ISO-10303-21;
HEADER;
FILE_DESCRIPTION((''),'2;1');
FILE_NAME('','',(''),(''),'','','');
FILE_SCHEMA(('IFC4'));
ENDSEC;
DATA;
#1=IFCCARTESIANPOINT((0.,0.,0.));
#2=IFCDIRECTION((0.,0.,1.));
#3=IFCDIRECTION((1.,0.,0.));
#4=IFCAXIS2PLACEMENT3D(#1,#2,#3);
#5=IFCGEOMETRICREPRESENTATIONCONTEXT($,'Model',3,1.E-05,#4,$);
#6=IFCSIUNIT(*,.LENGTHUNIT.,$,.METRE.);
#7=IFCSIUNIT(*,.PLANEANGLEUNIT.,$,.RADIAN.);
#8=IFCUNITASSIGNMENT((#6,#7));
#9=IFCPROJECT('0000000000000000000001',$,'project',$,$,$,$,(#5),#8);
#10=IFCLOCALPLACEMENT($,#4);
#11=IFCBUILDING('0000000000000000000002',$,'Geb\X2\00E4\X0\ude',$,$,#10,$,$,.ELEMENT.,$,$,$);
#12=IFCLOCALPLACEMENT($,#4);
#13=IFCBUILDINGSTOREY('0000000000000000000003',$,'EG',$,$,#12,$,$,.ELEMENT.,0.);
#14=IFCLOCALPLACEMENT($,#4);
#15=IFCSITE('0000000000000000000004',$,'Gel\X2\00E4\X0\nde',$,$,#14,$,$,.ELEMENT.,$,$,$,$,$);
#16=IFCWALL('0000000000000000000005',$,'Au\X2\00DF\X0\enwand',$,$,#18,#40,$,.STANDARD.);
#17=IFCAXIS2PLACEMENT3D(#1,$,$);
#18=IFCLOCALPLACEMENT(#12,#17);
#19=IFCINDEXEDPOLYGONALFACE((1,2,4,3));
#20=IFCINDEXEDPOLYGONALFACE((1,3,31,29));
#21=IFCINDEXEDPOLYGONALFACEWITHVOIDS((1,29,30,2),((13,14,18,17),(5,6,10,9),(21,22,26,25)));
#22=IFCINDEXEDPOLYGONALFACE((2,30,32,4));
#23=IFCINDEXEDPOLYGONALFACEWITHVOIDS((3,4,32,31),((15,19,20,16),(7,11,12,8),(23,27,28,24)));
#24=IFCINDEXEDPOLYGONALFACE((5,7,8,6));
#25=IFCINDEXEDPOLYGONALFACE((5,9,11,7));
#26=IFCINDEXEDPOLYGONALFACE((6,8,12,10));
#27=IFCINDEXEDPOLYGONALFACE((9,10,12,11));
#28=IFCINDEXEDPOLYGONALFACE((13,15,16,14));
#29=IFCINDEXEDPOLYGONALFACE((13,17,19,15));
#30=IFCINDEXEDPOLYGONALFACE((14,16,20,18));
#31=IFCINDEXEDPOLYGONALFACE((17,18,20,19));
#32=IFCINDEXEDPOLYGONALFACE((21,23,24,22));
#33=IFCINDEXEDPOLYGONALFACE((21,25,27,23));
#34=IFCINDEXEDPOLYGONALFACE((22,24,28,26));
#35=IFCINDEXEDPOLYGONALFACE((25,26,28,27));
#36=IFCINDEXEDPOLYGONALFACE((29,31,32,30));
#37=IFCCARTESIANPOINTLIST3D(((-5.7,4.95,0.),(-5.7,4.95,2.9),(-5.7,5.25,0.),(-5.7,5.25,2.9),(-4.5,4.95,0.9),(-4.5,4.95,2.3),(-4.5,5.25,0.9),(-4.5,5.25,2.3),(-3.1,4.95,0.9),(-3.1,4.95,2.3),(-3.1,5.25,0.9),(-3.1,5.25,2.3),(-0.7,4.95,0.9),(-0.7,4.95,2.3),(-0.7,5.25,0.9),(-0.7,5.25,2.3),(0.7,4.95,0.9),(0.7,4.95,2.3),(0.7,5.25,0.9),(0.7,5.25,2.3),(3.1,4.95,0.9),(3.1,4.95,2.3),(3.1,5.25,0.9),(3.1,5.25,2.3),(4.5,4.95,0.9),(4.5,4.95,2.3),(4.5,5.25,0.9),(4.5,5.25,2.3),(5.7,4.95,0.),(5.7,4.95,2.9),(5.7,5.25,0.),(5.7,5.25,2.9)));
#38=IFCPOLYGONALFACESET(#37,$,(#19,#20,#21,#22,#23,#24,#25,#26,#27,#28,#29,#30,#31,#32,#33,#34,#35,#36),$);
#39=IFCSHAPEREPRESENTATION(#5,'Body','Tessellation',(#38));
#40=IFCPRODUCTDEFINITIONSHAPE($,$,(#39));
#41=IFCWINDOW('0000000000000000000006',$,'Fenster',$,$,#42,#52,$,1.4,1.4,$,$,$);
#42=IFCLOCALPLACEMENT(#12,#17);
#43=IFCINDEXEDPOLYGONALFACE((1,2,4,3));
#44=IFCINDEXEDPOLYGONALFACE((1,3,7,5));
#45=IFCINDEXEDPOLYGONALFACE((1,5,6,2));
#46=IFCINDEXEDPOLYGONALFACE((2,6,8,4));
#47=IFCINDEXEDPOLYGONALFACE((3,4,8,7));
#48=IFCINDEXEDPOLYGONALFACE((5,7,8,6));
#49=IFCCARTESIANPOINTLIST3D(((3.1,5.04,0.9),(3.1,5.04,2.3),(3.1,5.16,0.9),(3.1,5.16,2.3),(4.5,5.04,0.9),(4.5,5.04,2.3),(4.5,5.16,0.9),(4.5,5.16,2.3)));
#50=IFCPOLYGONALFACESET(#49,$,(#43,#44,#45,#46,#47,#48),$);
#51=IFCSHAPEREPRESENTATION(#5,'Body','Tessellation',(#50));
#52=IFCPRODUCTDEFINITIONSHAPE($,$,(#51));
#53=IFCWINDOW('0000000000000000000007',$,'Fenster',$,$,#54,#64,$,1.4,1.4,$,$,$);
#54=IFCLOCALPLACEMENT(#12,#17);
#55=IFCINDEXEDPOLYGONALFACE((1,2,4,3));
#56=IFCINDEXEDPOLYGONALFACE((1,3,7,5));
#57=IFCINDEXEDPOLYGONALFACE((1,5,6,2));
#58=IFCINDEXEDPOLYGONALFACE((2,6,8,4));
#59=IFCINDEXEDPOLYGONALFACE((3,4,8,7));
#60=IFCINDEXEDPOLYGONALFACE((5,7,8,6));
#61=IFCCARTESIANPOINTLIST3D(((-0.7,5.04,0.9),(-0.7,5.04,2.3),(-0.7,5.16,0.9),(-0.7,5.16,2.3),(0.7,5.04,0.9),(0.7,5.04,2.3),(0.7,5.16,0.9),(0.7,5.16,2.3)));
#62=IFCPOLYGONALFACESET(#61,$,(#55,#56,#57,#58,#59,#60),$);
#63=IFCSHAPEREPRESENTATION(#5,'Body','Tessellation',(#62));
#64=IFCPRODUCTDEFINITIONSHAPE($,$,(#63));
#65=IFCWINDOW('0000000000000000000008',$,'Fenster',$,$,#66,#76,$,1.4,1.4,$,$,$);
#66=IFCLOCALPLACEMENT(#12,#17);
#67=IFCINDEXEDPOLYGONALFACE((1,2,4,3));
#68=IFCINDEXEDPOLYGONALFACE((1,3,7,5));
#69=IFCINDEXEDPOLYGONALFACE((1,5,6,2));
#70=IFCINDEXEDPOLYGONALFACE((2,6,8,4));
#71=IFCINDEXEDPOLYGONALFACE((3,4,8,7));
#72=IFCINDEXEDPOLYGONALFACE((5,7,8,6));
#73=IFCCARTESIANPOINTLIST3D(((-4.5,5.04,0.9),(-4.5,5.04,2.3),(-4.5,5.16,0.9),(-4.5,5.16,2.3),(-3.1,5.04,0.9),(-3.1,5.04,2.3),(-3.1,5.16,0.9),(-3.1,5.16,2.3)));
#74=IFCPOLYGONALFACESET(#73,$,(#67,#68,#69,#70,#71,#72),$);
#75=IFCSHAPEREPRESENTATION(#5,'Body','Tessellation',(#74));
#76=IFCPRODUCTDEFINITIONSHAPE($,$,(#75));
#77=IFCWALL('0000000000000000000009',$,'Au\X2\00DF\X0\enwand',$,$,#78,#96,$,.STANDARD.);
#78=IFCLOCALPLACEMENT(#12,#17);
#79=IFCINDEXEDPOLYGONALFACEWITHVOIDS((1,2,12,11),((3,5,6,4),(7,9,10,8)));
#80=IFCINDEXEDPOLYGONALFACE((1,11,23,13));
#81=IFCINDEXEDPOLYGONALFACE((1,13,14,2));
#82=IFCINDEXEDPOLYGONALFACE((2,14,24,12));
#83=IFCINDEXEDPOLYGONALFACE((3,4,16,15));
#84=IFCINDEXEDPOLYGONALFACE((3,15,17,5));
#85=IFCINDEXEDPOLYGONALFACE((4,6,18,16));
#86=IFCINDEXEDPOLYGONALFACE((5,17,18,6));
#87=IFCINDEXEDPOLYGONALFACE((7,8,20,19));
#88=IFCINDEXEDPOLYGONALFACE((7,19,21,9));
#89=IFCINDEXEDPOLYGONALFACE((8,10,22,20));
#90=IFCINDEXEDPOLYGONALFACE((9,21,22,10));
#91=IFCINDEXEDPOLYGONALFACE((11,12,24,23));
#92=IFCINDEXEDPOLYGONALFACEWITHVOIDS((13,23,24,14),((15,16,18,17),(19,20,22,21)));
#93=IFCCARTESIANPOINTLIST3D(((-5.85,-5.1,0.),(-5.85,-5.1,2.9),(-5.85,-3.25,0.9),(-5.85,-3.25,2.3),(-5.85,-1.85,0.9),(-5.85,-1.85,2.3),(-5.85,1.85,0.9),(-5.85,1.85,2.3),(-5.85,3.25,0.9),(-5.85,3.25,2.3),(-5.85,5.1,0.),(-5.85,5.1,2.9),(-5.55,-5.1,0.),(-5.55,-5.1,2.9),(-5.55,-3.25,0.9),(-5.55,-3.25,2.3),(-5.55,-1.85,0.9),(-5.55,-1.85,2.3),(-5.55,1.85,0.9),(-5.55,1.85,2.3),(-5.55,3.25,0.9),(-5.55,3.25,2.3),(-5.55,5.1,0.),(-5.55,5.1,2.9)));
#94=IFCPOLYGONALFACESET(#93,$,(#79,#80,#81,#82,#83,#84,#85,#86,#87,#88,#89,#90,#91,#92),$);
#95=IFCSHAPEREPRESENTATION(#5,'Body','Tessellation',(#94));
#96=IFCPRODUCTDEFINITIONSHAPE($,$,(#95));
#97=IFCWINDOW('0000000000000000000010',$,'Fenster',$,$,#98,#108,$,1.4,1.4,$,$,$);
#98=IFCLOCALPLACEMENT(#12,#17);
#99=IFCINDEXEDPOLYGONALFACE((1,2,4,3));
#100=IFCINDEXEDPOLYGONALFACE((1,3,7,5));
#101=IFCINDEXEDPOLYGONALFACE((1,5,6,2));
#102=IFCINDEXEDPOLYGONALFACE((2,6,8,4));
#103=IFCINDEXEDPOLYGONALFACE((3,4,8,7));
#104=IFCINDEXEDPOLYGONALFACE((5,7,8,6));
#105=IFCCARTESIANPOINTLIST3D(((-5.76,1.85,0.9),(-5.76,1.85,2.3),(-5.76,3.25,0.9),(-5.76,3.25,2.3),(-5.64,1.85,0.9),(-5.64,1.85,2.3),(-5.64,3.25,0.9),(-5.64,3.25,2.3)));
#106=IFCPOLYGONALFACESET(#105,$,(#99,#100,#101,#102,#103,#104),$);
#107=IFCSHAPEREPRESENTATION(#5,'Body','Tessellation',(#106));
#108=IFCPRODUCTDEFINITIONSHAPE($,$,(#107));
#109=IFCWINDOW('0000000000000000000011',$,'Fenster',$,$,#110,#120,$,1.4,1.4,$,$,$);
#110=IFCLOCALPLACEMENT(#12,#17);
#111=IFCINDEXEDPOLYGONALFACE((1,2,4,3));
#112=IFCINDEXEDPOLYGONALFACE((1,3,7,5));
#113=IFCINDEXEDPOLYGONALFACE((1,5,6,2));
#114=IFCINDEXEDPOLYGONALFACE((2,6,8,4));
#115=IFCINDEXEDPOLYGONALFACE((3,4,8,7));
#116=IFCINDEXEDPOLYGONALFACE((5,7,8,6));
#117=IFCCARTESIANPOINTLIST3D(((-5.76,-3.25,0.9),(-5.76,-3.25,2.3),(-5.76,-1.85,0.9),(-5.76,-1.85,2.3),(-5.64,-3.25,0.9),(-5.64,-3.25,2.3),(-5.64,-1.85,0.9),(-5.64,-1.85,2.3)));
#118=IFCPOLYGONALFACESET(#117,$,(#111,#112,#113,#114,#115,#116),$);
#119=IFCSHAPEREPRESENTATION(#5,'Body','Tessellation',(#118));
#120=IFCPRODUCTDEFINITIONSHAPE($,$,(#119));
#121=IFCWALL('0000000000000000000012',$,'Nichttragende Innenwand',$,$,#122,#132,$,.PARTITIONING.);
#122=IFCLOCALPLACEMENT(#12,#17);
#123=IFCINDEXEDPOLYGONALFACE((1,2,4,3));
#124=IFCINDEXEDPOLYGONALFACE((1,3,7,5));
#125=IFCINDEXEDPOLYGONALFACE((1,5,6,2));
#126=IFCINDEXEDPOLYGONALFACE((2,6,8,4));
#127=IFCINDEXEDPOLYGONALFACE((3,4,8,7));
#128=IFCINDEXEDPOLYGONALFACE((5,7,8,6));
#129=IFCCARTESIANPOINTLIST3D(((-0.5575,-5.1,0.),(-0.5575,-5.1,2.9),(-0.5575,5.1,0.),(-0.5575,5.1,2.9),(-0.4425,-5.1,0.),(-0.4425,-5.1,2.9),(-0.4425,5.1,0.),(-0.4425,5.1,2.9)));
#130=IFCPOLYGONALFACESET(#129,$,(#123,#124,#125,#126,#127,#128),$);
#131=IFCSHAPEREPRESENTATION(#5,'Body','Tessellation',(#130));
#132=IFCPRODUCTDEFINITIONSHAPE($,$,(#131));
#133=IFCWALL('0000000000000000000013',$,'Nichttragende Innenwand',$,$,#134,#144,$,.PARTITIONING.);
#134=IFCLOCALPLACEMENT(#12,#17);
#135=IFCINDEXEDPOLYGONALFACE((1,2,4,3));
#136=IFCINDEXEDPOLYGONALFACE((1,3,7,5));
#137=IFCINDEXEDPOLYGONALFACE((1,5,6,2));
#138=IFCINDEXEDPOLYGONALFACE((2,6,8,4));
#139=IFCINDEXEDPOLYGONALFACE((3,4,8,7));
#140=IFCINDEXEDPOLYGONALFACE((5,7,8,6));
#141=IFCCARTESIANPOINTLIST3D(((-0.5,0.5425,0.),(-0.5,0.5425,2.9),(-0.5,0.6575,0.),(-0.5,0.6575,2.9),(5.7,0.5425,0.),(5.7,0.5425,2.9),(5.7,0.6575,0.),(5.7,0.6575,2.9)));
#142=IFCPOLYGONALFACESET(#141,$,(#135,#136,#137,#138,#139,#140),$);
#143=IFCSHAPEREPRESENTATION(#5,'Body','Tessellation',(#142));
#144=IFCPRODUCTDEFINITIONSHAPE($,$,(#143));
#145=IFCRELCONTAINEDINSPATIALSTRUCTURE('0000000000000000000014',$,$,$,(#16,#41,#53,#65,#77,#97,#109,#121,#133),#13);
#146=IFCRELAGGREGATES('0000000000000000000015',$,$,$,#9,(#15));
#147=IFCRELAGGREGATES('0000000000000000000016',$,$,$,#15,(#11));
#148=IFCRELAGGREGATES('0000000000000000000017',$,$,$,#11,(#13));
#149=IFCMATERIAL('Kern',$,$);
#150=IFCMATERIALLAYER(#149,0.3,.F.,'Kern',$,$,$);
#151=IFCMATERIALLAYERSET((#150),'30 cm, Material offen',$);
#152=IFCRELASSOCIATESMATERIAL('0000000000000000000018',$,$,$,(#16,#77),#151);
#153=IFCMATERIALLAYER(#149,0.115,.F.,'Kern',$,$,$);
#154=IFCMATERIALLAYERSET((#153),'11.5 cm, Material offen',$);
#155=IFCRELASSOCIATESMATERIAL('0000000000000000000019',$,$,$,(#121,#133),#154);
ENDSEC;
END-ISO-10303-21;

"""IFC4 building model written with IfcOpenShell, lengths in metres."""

from ifc_helpers import new_model, si_unit, frame, origin_with_axes, origin_2d, place, context, project, spatial, rectangle, extrude, material, layer, layer_set, element, fill, save


model = new_model("IFC4")

# Units and contexts
model_context = context("Model", 3, precision=1e-05, world=origin_with_axes())
ifc_project = project(units=[si_unit("LENGTHUNIT", "METRE"), si_unit("PLANEANGLEUNIT", "RADIAN")], contexts=[model_context])

# Site, building, storey
site_placement = place(None, origin_with_axes())
site = spatial("IfcSite", under=ifc_project, at=site_placement, Name="Gelände", CompositionType="ELEMENT")
building_placement = place(None, origin_with_axes())
building = spatial("IfcBuilding", under=site, at=building_placement, Name="Gebäude", CompositionType="ELEMENT")
storey_placement = place(None, origin_with_axes())
storey = spatial("IfcBuildingStorey", under=building, at=storey_placement, Name="EG", CompositionType="ELEMENT", Elevation=0.0)

# Shared definitions
ifc_material = material(Name="Kern")
ifc_layer_1 = layer(ifc_material, 0.3, ventilated=False, Name="Kern")
ifc_layer_set_1 = layer_set([ifc_layer_1], Name="30 cm, Material offen")

# Walls, openings, windows
wall_1_placement = place(None, frame((0.0, 5.1, 0.0), z_axis=(0.0, 0.0, 1.0), x_axis=(-1.0, 0.0, 0.0)))
wall_1 = element("IfcWall", 1, at=wall_1_placement, inside=storey, material=ifc_layer_set_1, Name="Außenwand", PredefinedType="STANDARD", context=model_context, shape_type="SweptSolid", body=[
    extrude(rectangle(XDim=11.4, YDim=0.3, at=origin_2d()), origin_with_axes(), (0.0, 0.0, 1.0), 2.9),
])
opening_1_placement = place(wall_1_placement, frame((-3.8, 0.0, 0.9), z_axis=(0.0, 0.0, 1.0), x_axis=(1.0, 0.0, 0.0)))
opening_1 = element("IfcOpeningElement", 2, at=opening_1_placement, cuts=wall_1, PredefinedType="OPENING", context=model_context, shape_type="SweptSolid", body=[
    extrude(rectangle(XDim=1.4, YDim=0.34, at=origin_2d()), origin_with_axes(), (0.0, 0.0, 1.0), 1.4),
])
opening_2_placement = place(wall_1_placement, frame((0.0, 0.0, 0.9), z_axis=(0.0, 0.0, 1.0), x_axis=(1.0, 0.0, 0.0)))
opening_2 = element("IfcOpeningElement", 3, at=opening_2_placement, cuts=wall_1, PredefinedType="OPENING", context=model_context, shape_type="SweptSolid", body=[
    extrude(rectangle(XDim=1.4, YDim=0.34, at=origin_2d()), origin_with_axes(), (0.0, 0.0, 1.0), 1.4),
])
opening_3_placement = place(wall_1_placement, frame((3.8, 0.0, 0.9), z_axis=(0.0, 0.0, 1.0), x_axis=(1.0, 0.0, 0.0)))
opening_3 = element("IfcOpeningElement", 4, at=opening_3_placement, cuts=wall_1, PredefinedType="OPENING", context=model_context, shape_type="SweptSolid", body=[
    extrude(rectangle(XDim=1.4, YDim=0.34, at=origin_2d()), origin_with_axes(), (0.0, 0.0, 1.0), 1.4),
])
window_1_placement = place(opening_1_placement, origin_with_axes())
window_1 = element("IfcWindow", 5, at=window_1_placement, inside=storey, Name="Fenster", OverallHeight=1.4, OverallWidth=1.4, context=model_context, shape_type="SweptSolid", body=[
    extrude(rectangle(XDim=1.4, YDim=0.12, at=origin_2d()), origin_with_axes(), (0.0, 0.0, 1.0), 1.4),
])
fill(opening_1, window_1)
window_2_placement = place(opening_2_placement, origin_with_axes())
window_2 = element("IfcWindow", 6, at=window_2_placement, inside=storey, Name="Fenster", OverallHeight=1.4, OverallWidth=1.4, context=model_context, shape_type="SweptSolid", body=[
    extrude(rectangle(XDim=1.4, YDim=0.12, at=origin_2d()), origin_with_axes(), (0.0, 0.0, 1.0), 1.4),
])
fill(opening_2, window_2)
window_3_placement = place(opening_3_placement, origin_with_axes())
window_3 = element("IfcWindow", 7, at=window_3_placement, inside=storey, Name="Fenster", OverallHeight=1.4, OverallWidth=1.4, context=model_context, shape_type="SweptSolid", body=[
    extrude(rectangle(XDim=1.4, YDim=0.12, at=origin_2d()), origin_with_axes(), (0.0, 0.0, 1.0), 1.4),
])
fill(opening_3, window_3)
wall_2_placement = place(None, frame((-5.7, 0.0, 0.0), z_axis=(0.0, 0.0, 1.0), x_axis=(0.0, -1.0, 0.0)))
wall_2 = element("IfcWall", 8, at=wall_2_placement, inside=storey, material=ifc_layer_set_1, Name="Außenwand", PredefinedType="STANDARD", context=model_context, shape_type="SweptSolid", body=[
    extrude(rectangle(XDim=10.2, YDim=0.3, at=origin_2d()), origin_with_axes(), (0.0, 0.0, 1.0), 2.9),
])
opening_4_placement = place(wall_2_placement, frame((-2.55, 0.0, 0.9), z_axis=(0.0, 0.0, 1.0), x_axis=(1.0, 0.0, 0.0)))
opening_4 = element("IfcOpeningElement", 9, at=opening_4_placement, cuts=wall_2, PredefinedType="OPENING", context=model_context, shape_type="SweptSolid", body=[
    extrude(rectangle(XDim=1.4, YDim=0.34, at=origin_2d()), origin_with_axes(), (0.0, 0.0, 1.0), 1.4),
])
opening_5_placement = place(wall_2_placement, frame((2.55, 0.0, 0.9), z_axis=(0.0, 0.0, 1.0), x_axis=(1.0, 0.0, 0.0)))
opening_5 = element("IfcOpeningElement", 10, at=opening_5_placement, cuts=wall_2, PredefinedType="OPENING", context=model_context, shape_type="SweptSolid", body=[
    extrude(rectangle(XDim=1.4, YDim=0.34, at=origin_2d()), origin_with_axes(), (0.0, 0.0, 1.0), 1.4),
])
window_4_placement = place(opening_4_placement, origin_with_axes())
window_4 = element("IfcWindow", 11, at=window_4_placement, inside=storey, Name="Fenster", OverallHeight=1.4, OverallWidth=1.4, context=model_context, shape_type="SweptSolid", body=[
    extrude(rectangle(XDim=1.4, YDim=0.12, at=origin_2d()), origin_with_axes(), (0.0, 0.0, 1.0), 1.4),
])
fill(opening_4, window_4)
window_5_placement = place(opening_5_placement, origin_with_axes())
window_5 = element("IfcWindow", 12, at=window_5_placement, inside=storey, Name="Fenster", OverallHeight=1.4, OverallWidth=1.4, context=model_context, shape_type="SweptSolid", body=[
    extrude(rectangle(XDim=1.4, YDim=0.12, at=origin_2d()), origin_with_axes(), (0.0, 0.0, 1.0), 1.4),
])
fill(opening_5, window_5)

# Walls
ifc_layer_2 = layer(ifc_material, 0.115, ventilated=False, Name="Kern")
ifc_layer_set_2 = layer_set([ifc_layer_2], Name="11.5 cm, Material offen")
wall_3_placement = place(None, frame((-0.5, 0.0, 0.0), z_axis=(0.0, 0.0, 1.0), x_axis=(0.0, 1.0, 0.0)))
element("IfcWall", 13, at=wall_3_placement, inside=storey, material=ifc_layer_set_2, Name="Nichttragende Innenwand", PredefinedType="PARTITIONING", context=model_context, shape_type="SweptSolid", body=[
    extrude(rectangle(XDim=10.2, YDim=0.115, at=origin_2d()), origin_with_axes(), (0.0, 0.0, 1.0), 2.9),
])
wall_4_placement = place(None, frame((2.6, 0.6, 0.0), z_axis=(0.0, 0.0, 1.0), x_axis=(1.0, 0.0, 0.0)))
element("IfcWall", 14, at=wall_4_placement, inside=storey, material=ifc_layer_set_2, Name="Nichttragende Innenwand", PredefinedType="PARTITIONING", context=model_context, shape_type="SweptSolid", body=[
    extrude(rectangle(XDim=6.2, YDim=0.115, at=origin_2d()), origin_with_axes(), (0.0, 0.0, 1.0), 2.9),
])

save(model, "model.ifc")
